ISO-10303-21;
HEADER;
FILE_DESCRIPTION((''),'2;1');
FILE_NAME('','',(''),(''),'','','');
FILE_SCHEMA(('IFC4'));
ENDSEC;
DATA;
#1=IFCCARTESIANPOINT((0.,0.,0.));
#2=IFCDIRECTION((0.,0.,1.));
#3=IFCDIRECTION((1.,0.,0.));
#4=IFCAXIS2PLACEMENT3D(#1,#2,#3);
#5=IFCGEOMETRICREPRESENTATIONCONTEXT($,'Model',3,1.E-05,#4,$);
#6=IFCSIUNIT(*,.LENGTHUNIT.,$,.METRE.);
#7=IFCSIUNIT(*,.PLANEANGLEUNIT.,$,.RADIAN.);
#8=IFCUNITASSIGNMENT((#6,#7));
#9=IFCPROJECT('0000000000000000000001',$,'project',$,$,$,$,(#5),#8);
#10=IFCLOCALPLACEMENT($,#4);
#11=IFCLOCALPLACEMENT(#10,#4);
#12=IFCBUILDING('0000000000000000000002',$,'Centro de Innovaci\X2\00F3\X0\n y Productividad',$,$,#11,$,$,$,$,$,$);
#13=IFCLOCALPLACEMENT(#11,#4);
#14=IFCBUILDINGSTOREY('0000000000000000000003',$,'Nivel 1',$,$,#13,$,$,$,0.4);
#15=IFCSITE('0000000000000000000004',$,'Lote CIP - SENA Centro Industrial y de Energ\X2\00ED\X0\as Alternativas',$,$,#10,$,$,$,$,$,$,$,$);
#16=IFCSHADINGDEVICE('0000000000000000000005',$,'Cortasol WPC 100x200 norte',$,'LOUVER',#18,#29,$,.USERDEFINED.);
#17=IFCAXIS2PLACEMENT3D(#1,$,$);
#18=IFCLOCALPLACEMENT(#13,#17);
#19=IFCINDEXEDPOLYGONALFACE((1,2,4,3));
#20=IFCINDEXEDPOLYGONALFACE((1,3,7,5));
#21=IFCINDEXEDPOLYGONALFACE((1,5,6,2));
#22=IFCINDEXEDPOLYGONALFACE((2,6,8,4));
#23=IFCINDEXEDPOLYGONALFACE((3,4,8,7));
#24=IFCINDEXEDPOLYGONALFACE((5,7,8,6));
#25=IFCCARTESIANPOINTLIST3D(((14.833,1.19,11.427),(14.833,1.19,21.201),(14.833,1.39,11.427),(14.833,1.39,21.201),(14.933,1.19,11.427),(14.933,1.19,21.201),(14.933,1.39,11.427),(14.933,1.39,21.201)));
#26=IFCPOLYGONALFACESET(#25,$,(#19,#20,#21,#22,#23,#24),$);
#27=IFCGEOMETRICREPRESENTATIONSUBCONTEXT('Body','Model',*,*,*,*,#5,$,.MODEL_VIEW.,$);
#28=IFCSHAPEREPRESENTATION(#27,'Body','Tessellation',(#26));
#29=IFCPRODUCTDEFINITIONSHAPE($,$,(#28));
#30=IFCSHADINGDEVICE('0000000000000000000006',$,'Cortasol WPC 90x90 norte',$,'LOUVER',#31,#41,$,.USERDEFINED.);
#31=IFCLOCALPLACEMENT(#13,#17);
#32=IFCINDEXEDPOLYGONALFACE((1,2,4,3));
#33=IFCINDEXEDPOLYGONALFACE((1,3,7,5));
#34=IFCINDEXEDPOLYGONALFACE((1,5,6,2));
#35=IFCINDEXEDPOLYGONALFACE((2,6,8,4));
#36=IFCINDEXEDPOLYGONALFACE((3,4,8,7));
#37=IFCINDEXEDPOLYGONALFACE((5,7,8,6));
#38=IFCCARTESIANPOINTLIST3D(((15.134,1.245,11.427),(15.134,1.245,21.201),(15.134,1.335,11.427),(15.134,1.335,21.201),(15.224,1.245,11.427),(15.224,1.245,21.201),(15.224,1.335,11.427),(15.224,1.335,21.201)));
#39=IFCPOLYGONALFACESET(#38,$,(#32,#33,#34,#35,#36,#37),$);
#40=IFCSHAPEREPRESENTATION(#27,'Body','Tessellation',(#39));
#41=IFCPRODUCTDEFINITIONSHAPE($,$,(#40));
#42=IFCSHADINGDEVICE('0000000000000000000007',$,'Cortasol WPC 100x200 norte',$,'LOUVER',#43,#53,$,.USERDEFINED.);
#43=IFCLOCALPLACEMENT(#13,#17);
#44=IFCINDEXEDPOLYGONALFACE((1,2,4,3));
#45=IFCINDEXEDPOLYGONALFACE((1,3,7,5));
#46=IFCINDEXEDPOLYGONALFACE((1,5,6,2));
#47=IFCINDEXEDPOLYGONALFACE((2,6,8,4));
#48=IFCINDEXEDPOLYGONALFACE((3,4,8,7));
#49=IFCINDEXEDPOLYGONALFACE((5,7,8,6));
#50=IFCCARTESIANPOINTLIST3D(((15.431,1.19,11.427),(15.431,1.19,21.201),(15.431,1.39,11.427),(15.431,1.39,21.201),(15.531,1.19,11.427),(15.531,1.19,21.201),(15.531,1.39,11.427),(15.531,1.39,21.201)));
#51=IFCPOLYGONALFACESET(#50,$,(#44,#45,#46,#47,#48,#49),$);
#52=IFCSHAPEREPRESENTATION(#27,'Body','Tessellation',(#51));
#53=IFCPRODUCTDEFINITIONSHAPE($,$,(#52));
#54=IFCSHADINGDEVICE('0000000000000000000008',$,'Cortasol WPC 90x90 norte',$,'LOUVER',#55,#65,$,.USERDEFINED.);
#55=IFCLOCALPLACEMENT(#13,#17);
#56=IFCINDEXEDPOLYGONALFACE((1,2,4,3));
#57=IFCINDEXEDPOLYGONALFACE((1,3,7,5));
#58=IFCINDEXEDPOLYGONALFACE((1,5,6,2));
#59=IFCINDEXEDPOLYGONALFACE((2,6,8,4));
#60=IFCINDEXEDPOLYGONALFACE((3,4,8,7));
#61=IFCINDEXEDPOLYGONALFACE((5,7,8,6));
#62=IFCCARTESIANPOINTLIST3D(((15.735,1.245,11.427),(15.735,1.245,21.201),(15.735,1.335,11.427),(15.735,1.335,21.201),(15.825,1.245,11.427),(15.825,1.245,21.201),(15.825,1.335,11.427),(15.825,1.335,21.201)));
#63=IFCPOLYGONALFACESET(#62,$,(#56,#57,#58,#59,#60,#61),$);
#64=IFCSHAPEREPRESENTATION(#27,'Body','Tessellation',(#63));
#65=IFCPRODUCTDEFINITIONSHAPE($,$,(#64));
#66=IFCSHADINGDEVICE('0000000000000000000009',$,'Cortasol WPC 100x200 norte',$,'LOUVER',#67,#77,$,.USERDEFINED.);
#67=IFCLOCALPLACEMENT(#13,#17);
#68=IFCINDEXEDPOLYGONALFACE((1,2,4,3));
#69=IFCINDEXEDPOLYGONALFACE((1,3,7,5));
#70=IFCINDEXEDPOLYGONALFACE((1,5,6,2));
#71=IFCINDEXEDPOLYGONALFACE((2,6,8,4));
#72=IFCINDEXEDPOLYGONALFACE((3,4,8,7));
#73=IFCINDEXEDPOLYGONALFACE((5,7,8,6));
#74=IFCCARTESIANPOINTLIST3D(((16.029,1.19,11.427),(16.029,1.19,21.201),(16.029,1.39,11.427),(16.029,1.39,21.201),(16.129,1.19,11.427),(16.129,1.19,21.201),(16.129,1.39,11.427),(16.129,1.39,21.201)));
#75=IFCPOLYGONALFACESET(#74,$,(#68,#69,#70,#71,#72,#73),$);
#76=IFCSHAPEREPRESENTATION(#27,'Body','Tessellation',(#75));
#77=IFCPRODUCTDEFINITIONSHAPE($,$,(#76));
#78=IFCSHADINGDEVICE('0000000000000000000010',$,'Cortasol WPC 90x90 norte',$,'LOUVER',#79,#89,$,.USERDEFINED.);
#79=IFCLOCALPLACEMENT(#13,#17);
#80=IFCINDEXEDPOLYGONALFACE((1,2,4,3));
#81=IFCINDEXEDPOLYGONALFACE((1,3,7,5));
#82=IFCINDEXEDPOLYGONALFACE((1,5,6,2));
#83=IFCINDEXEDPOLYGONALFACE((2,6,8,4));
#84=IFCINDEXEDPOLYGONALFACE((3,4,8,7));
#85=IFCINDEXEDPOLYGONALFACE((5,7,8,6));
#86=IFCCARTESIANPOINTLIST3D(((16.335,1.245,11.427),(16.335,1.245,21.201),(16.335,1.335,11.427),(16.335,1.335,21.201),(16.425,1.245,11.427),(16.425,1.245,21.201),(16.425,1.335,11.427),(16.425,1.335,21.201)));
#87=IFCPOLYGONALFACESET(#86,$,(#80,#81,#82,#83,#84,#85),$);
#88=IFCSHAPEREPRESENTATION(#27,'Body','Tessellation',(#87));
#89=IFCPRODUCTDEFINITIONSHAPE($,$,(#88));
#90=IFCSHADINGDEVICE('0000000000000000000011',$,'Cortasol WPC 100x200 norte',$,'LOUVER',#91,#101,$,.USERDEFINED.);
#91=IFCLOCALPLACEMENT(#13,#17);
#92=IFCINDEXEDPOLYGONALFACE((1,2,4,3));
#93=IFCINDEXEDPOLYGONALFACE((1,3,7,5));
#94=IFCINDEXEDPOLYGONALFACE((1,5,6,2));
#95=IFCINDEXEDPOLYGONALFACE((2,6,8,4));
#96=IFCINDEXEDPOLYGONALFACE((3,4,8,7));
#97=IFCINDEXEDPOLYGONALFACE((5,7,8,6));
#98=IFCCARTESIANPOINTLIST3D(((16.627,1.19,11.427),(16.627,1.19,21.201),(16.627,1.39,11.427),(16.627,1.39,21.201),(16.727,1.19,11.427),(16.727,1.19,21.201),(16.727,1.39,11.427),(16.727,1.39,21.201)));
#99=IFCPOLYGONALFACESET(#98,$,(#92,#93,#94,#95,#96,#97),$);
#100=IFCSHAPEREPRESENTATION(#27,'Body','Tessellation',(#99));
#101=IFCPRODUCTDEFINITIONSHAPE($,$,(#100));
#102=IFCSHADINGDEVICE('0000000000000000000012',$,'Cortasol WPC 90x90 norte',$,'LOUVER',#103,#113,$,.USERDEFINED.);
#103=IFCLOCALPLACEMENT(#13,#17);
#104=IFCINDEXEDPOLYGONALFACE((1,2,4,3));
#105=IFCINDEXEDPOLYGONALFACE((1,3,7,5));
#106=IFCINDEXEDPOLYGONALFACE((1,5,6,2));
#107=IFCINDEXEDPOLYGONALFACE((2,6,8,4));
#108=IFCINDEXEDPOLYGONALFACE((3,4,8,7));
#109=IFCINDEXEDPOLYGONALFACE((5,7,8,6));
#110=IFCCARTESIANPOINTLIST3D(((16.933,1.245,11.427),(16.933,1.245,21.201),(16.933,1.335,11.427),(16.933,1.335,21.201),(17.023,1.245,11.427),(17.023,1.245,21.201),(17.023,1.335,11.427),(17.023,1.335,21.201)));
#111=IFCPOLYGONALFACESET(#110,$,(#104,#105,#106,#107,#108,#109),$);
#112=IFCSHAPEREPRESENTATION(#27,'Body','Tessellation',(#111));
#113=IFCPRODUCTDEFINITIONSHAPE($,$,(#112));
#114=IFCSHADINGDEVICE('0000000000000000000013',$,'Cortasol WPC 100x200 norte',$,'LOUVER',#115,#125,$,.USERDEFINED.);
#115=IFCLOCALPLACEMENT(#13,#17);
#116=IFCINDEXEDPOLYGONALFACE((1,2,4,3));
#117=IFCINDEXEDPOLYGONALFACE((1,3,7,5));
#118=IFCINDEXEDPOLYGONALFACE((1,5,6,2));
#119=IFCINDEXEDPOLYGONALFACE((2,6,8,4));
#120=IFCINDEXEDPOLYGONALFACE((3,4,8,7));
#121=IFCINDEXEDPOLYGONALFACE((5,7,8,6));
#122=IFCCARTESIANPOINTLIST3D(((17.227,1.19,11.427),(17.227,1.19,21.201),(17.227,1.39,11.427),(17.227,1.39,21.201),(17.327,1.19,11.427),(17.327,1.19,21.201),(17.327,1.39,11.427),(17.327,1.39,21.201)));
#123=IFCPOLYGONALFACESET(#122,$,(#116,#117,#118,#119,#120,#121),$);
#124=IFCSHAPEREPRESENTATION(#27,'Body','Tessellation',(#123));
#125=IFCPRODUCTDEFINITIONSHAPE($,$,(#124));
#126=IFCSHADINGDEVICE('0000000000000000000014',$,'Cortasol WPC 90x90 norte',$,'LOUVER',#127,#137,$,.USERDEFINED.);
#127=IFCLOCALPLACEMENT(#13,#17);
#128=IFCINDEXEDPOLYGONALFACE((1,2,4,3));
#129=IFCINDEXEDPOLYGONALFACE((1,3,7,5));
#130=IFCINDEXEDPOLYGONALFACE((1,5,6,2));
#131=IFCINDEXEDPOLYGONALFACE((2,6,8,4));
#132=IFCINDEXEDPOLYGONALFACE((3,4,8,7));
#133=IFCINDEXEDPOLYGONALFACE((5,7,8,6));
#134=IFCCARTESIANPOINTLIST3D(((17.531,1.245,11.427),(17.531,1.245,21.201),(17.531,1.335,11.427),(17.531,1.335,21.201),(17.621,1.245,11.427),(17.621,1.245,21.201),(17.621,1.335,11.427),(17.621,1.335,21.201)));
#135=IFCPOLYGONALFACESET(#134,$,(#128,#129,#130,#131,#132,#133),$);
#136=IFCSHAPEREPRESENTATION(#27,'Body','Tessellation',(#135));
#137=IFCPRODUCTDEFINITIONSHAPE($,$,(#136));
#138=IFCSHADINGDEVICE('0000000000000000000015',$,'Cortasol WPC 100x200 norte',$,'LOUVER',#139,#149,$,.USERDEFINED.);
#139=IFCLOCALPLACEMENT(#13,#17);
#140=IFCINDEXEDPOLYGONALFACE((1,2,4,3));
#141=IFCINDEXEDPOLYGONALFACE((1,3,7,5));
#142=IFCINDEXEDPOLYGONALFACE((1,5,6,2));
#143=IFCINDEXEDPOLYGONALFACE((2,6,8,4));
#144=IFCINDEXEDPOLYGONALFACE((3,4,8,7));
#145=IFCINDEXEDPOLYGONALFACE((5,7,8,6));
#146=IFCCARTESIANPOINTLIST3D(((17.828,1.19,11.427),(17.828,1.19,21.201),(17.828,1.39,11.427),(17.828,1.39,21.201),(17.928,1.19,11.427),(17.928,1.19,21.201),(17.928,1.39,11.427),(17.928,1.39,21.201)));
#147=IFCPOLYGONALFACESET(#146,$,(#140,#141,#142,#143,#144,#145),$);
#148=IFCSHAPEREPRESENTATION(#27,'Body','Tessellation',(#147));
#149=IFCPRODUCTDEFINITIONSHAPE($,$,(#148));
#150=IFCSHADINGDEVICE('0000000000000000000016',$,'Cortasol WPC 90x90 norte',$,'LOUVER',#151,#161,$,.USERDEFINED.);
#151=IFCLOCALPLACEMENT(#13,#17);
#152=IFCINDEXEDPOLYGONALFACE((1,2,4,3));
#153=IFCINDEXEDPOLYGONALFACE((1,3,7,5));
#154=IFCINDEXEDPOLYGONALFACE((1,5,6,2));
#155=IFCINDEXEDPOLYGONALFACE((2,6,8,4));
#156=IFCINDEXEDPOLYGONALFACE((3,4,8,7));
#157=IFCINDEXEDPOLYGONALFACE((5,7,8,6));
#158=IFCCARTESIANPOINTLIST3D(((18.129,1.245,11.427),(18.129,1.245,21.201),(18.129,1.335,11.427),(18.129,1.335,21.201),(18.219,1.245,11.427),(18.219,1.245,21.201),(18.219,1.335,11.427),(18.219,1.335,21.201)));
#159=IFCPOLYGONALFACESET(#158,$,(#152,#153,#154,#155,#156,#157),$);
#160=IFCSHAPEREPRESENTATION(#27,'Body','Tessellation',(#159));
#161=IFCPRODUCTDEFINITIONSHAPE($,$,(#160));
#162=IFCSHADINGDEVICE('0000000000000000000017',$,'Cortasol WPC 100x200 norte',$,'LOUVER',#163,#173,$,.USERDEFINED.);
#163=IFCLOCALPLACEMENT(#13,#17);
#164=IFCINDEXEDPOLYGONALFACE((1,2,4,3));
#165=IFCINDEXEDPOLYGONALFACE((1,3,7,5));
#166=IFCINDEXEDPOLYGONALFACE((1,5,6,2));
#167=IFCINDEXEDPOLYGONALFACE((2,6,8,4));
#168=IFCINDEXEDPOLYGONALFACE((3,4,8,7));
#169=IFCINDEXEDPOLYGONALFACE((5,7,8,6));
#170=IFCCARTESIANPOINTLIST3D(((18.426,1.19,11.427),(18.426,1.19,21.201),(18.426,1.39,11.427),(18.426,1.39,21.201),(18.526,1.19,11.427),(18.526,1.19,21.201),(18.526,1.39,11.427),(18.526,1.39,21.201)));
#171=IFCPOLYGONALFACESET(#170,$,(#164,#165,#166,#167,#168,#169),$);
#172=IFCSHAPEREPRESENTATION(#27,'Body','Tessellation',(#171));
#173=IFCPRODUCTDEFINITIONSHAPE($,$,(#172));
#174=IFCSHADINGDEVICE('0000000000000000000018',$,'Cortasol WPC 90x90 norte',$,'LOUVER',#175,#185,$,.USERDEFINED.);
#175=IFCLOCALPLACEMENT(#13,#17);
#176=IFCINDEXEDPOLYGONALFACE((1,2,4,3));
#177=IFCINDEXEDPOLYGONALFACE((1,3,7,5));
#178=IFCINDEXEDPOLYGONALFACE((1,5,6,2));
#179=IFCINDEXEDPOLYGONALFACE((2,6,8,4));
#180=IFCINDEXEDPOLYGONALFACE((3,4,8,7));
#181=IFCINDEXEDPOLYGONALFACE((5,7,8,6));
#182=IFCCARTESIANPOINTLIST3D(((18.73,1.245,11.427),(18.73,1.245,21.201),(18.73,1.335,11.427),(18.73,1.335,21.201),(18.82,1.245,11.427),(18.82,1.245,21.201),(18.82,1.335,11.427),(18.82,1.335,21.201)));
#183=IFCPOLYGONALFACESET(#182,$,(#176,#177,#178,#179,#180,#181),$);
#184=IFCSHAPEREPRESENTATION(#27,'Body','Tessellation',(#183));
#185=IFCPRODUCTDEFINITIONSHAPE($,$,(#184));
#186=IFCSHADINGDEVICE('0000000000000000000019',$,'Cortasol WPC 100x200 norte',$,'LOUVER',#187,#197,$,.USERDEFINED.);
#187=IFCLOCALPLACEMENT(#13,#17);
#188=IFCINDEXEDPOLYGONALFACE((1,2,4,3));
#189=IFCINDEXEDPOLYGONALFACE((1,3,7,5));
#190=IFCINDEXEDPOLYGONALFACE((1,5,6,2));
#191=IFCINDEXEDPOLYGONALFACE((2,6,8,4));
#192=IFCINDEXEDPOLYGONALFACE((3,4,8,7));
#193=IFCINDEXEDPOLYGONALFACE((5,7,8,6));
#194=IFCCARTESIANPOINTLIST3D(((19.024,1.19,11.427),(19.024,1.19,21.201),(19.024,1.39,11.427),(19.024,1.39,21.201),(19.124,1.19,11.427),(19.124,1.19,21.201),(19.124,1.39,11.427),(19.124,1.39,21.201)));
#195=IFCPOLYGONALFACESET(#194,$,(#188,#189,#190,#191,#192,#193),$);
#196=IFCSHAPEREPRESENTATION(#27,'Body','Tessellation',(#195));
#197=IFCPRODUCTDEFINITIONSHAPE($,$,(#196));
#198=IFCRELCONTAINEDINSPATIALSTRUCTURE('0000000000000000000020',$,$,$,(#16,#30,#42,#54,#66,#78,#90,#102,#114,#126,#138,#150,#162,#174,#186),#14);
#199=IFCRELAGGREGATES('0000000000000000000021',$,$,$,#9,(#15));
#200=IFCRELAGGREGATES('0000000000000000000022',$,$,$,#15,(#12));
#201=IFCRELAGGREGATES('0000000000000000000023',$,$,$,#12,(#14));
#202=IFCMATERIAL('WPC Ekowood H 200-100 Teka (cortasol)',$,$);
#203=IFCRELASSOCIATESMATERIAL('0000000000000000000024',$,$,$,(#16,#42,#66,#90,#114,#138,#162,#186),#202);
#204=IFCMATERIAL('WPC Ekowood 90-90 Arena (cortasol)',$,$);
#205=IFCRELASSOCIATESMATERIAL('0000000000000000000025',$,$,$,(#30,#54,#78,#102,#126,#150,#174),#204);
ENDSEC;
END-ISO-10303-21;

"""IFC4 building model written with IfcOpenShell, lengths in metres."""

from ifc_helpers import new_model, si_unit, frame, origin_with_axes, place, context, subcontext, project, spatial, polyline, outline, extrude, material, element, save


model = new_model("IFC4")

# Units and contexts
model_context = context("Model", 3, precision=1e-05, world=origin_with_axes())
body_context = subcontext(model_context, "Body", "Model", "MODEL_VIEW")
ifc_project = project(units=[si_unit("LENGTHUNIT", "METRE"), si_unit("PLANEANGLEUNIT", "RADIAN")], contexts=[model_context])

# Site, building, storey
site_placement = place(None, origin_with_axes())
site = spatial("IfcSite", under=ifc_project, at=site_placement, Name="Lote CIP - SENA Centro Industrial y de Energías Alternativas")
building_placement = place(site_placement, origin_with_axes())
building = spatial("IfcBuilding", under=site, at=building_placement, Name="Centro de Innovación y Productividad")
storey_placement = place(building_placement, origin_with_axes())
storey = spatial("IfcBuildingStorey", under=building, at=storey_placement, Name="Nivel 1", Elevation=0.4)

# Shading devices
ifc_material_1 = material(Name="WPC Ekowood H 200-100 Teka (cortasol)")
shading_device_1_placement = place(storey_placement, origin_with_axes())
element("IfcShadingDevice", 1, at=shading_device_1_placement, inside=storey, material=ifc_material_1, Name="Cortasol WPC 100x200 norte", ObjectType="LOUVER", PredefinedType="USERDEFINED", context=body_context, shape_type="SweptSolid", body=[
    extrude(outline(polyline([(14.833, 1.19), (14.833, 1.39), (14.933, 1.39), (14.933, 1.19), (14.833, 1.19)])), frame((0.0, 0.0, 11.427)), (0.0, 0.0, 1.0), 9.774),
])
ifc_material_2 = material(Name="WPC Ekowood 90-90 Arena (cortasol)")
shading_device_2_placement = place(storey_placement, origin_with_axes())
element("IfcShadingDevice", 2, at=shading_device_2_placement, inside=storey, material=ifc_material_2, Name="Cortasol WPC 90x90 norte", ObjectType="LOUVER", PredefinedType="USERDEFINED", context=body_context, shape_type="SweptSolid", body=[
    extrude(outline(polyline([(15.134, 1.245), (15.134, 1.335), (15.224, 1.335), (15.224, 1.245), (15.134, 1.245)])), frame((0.0, 0.0, 11.427)), (0.0, 0.0, 1.0), 9.774),
])
shading_device_3_placement = place(storey_placement, origin_with_axes())
element("IfcShadingDevice", 3, at=shading_device_3_placement, inside=storey, material=ifc_material_1, Name="Cortasol WPC 100x200 norte", ObjectType="LOUVER", PredefinedType="USERDEFINED", context=body_context, shape_type="SweptSolid", body=[
    extrude(outline(polyline([(15.431, 1.19), (15.431, 1.39), (15.531, 1.39), (15.531, 1.19), (15.431, 1.19)])), frame((0.0, 0.0, 11.427)), (0.0, 0.0, 1.0), 9.774),
])
shading_device_4_placement = place(storey_placement, origin_with_axes())
element("IfcShadingDevice", 4, at=shading_device_4_placement, inside=storey, material=ifc_material_2, Name="Cortasol WPC 90x90 norte", ObjectType="LOUVER", PredefinedType="USERDEFINED", context=body_context, shape_type="SweptSolid", body=[
    extrude(outline(polyline([(15.735, 1.245), (15.735, 1.335), (15.825, 1.335), (15.825, 1.245), (15.735, 1.245)])), frame((0.0, 0.0, 11.427)), (0.0, 0.0, 1.0), 9.774),
])
shading_device_5_placement = place(storey_placement, origin_with_axes())
element("IfcShadingDevice", 5, at=shading_device_5_placement, inside=storey, material=ifc_material_1, Name="Cortasol WPC 100x200 norte", ObjectType="LOUVER", PredefinedType="USERDEFINED", context=body_context, shape_type="SweptSolid", body=[
    extrude(outline(polyline([(16.029, 1.19), (16.029, 1.39), (16.129, 1.39), (16.129, 1.19), (16.029, 1.19)])), frame((0.0, 0.0, 11.427)), (0.0, 0.0, 1.0), 9.774),
])
shading_device_6_placement = place(storey_placement, origin_with_axes())
element("IfcShadingDevice", 6, at=shading_device_6_placement, inside=storey, material=ifc_material_2, Name="Cortasol WPC 90x90 norte", ObjectType="LOUVER", PredefinedType="USERDEFINED", context=body_context, shape_type="SweptSolid", body=[
    extrude(outline(polyline([(16.335, 1.245), (16.335, 1.335), (16.425, 1.335), (16.425, 1.245), (16.335, 1.245)])), frame((0.0, 0.0, 11.427)), (0.0, 0.0, 1.0), 9.774),
])
shading_device_7_placement = place(storey_placement, origin_with_axes())
element("IfcShadingDevice", 7, at=shading_device_7_placement, inside=storey, material=ifc_material_1, Name="Cortasol WPC 100x200 norte", ObjectType="LOUVER", PredefinedType="USERDEFINED", context=body_context, shape_type="SweptSolid", body=[
    extrude(outline(polyline([(16.627, 1.19), (16.627, 1.39), (16.727, 1.39), (16.727, 1.19), (16.627, 1.19)])), frame((0.0, 0.0, 11.427)), (0.0, 0.0, 1.0), 9.774),
])
shading_device_8_placement = place(storey_placement, origin_with_axes())
element("IfcShadingDevice", 8, at=shading_device_8_placement, inside=storey, material=ifc_material_2, Name="Cortasol WPC 90x90 norte", ObjectType="LOUVER", PredefinedType="USERDEFINED", context=body_context, shape_type="SweptSolid", body=[
    extrude(outline(polyline([(16.933, 1.245), (16.933, 1.335), (17.023, 1.335), (17.023, 1.245), (16.933, 1.245)])), frame((0.0, 0.0, 11.427)), (0.0, 0.0, 1.0), 9.774),
])
shading_device_9_placement = place(storey_placement, origin_with_axes())
element("IfcShadingDevice", 9, at=shading_device_9_placement, inside=storey, material=ifc_material_1, Name="Cortasol WPC 100x200 norte", ObjectType="LOUVER", PredefinedType="USERDEFINED", context=body_context, shape_type="SweptSolid", body=[
    extrude(outline(polyline([(17.227, 1.19), (17.227, 1.39), (17.327, 1.39), (17.327, 1.19), (17.227, 1.19)])), frame((0.0, 0.0, 11.427)), (0.0, 0.0, 1.0), 9.774),
])
shading_device_10_placement = place(storey_placement, origin_with_axes())
element("IfcShadingDevice", 10, at=shading_device_10_placement, inside=storey, material=ifc_material_2, Name="Cortasol WPC 90x90 norte", ObjectType="LOUVER", PredefinedType="USERDEFINED", context=body_context, shape_type="SweptSolid", body=[
    extrude(outline(polyline([(17.531, 1.245), (17.531, 1.335), (17.621, 1.335), (17.621, 1.245), (17.531, 1.245)])), frame((0.0, 0.0, 11.427)), (0.0, 0.0, 1.0), 9.774),
])
shading_device_11_placement = place(storey_placement, origin_with_axes())
element("IfcShadingDevice", 11, at=shading_device_11_placement, inside=storey, material=ifc_material_1, Name="Cortasol WPC 100x200 norte", ObjectType="LOUVER", PredefinedType="USERDEFINED", context=body_context, shape_type="SweptSolid", body=[
    extrude(outline(polyline([(17.828, 1.19), (17.828, 1.39), (17.928, 1.39), (17.928, 1.19), (17.828, 1.19)])), frame((0.0, 0.0, 11.427)), (0.0, 0.0, 1.0), 9.774),
])
shading_device_12_placement = place(storey_placement, origin_with_axes())
element("IfcShadingDevice", 12, at=shading_device_12_placement, inside=storey, material=ifc_material_2, Name="Cortasol WPC 90x90 norte", ObjectType="LOUVER", PredefinedType="USERDEFINED", context=body_context, shape_type="SweptSolid", body=[
    extrude(outline(polyline([(18.129, 1.245), (18.129, 1.335), (18.219, 1.335), (18.219, 1.245), (18.129, 1.245)])), frame((0.0, 0.0, 11.427)), (0.0, 0.0, 1.0), 9.774),
])
shading_device_13_placement = place(storey_placement, origin_with_axes())
element("IfcShadingDevice", 13, at=shading_device_13_placement, inside=storey, material=ifc_material_1, Name="Cortasol WPC 100x200 norte", ObjectType="LOUVER", PredefinedType="USERDEFINED", context=body_context, shape_type="SweptSolid", body=[
    extrude(outline(polyline([(18.426, 1.19), (18.426, 1.39), (18.526, 1.39), (18.526, 1.19), (18.426, 1.19)])), frame((0.0, 0.0, 11.427)), (0.0, 0.0, 1.0), 9.774),
])
shading_device_14_placement = place(storey_placement, origin_with_axes())
element("IfcShadingDevice", 14, at=shading_device_14_placement, inside=storey, material=ifc_material_2, Name="Cortasol WPC 90x90 norte", ObjectType="LOUVER", PredefinedType="USERDEFINED", context=body_context, shape_type="SweptSolid", body=[
    extrude(outline(polyline([(18.73, 1.245), (18.73, 1.335), (18.82, 1.335), (18.82, 1.245), (18.73, 1.245)])), frame((0.0, 0.0, 11.427)), (0.0, 0.0, 1.0), 9.774),
])
shading_device_15_placement = place(storey_placement, origin_with_axes())
element("IfcShadingDevice", 15, at=shading_device_15_placement, inside=storey, material=ifc_material_1, Name="Cortasol WPC 100x200 norte", ObjectType="LOUVER", PredefinedType="USERDEFINED", context=body_context, shape_type="SweptSolid", body=[
    extrude(outline(polyline([(19.024, 1.19), (19.024, 1.39), (19.124, 1.39), (19.124, 1.19), (19.024, 1.19)])), frame((0.0, 0.0, 11.427)), (0.0, 0.0, 1.0), 9.774),
])

save(model, "model.ifc")
